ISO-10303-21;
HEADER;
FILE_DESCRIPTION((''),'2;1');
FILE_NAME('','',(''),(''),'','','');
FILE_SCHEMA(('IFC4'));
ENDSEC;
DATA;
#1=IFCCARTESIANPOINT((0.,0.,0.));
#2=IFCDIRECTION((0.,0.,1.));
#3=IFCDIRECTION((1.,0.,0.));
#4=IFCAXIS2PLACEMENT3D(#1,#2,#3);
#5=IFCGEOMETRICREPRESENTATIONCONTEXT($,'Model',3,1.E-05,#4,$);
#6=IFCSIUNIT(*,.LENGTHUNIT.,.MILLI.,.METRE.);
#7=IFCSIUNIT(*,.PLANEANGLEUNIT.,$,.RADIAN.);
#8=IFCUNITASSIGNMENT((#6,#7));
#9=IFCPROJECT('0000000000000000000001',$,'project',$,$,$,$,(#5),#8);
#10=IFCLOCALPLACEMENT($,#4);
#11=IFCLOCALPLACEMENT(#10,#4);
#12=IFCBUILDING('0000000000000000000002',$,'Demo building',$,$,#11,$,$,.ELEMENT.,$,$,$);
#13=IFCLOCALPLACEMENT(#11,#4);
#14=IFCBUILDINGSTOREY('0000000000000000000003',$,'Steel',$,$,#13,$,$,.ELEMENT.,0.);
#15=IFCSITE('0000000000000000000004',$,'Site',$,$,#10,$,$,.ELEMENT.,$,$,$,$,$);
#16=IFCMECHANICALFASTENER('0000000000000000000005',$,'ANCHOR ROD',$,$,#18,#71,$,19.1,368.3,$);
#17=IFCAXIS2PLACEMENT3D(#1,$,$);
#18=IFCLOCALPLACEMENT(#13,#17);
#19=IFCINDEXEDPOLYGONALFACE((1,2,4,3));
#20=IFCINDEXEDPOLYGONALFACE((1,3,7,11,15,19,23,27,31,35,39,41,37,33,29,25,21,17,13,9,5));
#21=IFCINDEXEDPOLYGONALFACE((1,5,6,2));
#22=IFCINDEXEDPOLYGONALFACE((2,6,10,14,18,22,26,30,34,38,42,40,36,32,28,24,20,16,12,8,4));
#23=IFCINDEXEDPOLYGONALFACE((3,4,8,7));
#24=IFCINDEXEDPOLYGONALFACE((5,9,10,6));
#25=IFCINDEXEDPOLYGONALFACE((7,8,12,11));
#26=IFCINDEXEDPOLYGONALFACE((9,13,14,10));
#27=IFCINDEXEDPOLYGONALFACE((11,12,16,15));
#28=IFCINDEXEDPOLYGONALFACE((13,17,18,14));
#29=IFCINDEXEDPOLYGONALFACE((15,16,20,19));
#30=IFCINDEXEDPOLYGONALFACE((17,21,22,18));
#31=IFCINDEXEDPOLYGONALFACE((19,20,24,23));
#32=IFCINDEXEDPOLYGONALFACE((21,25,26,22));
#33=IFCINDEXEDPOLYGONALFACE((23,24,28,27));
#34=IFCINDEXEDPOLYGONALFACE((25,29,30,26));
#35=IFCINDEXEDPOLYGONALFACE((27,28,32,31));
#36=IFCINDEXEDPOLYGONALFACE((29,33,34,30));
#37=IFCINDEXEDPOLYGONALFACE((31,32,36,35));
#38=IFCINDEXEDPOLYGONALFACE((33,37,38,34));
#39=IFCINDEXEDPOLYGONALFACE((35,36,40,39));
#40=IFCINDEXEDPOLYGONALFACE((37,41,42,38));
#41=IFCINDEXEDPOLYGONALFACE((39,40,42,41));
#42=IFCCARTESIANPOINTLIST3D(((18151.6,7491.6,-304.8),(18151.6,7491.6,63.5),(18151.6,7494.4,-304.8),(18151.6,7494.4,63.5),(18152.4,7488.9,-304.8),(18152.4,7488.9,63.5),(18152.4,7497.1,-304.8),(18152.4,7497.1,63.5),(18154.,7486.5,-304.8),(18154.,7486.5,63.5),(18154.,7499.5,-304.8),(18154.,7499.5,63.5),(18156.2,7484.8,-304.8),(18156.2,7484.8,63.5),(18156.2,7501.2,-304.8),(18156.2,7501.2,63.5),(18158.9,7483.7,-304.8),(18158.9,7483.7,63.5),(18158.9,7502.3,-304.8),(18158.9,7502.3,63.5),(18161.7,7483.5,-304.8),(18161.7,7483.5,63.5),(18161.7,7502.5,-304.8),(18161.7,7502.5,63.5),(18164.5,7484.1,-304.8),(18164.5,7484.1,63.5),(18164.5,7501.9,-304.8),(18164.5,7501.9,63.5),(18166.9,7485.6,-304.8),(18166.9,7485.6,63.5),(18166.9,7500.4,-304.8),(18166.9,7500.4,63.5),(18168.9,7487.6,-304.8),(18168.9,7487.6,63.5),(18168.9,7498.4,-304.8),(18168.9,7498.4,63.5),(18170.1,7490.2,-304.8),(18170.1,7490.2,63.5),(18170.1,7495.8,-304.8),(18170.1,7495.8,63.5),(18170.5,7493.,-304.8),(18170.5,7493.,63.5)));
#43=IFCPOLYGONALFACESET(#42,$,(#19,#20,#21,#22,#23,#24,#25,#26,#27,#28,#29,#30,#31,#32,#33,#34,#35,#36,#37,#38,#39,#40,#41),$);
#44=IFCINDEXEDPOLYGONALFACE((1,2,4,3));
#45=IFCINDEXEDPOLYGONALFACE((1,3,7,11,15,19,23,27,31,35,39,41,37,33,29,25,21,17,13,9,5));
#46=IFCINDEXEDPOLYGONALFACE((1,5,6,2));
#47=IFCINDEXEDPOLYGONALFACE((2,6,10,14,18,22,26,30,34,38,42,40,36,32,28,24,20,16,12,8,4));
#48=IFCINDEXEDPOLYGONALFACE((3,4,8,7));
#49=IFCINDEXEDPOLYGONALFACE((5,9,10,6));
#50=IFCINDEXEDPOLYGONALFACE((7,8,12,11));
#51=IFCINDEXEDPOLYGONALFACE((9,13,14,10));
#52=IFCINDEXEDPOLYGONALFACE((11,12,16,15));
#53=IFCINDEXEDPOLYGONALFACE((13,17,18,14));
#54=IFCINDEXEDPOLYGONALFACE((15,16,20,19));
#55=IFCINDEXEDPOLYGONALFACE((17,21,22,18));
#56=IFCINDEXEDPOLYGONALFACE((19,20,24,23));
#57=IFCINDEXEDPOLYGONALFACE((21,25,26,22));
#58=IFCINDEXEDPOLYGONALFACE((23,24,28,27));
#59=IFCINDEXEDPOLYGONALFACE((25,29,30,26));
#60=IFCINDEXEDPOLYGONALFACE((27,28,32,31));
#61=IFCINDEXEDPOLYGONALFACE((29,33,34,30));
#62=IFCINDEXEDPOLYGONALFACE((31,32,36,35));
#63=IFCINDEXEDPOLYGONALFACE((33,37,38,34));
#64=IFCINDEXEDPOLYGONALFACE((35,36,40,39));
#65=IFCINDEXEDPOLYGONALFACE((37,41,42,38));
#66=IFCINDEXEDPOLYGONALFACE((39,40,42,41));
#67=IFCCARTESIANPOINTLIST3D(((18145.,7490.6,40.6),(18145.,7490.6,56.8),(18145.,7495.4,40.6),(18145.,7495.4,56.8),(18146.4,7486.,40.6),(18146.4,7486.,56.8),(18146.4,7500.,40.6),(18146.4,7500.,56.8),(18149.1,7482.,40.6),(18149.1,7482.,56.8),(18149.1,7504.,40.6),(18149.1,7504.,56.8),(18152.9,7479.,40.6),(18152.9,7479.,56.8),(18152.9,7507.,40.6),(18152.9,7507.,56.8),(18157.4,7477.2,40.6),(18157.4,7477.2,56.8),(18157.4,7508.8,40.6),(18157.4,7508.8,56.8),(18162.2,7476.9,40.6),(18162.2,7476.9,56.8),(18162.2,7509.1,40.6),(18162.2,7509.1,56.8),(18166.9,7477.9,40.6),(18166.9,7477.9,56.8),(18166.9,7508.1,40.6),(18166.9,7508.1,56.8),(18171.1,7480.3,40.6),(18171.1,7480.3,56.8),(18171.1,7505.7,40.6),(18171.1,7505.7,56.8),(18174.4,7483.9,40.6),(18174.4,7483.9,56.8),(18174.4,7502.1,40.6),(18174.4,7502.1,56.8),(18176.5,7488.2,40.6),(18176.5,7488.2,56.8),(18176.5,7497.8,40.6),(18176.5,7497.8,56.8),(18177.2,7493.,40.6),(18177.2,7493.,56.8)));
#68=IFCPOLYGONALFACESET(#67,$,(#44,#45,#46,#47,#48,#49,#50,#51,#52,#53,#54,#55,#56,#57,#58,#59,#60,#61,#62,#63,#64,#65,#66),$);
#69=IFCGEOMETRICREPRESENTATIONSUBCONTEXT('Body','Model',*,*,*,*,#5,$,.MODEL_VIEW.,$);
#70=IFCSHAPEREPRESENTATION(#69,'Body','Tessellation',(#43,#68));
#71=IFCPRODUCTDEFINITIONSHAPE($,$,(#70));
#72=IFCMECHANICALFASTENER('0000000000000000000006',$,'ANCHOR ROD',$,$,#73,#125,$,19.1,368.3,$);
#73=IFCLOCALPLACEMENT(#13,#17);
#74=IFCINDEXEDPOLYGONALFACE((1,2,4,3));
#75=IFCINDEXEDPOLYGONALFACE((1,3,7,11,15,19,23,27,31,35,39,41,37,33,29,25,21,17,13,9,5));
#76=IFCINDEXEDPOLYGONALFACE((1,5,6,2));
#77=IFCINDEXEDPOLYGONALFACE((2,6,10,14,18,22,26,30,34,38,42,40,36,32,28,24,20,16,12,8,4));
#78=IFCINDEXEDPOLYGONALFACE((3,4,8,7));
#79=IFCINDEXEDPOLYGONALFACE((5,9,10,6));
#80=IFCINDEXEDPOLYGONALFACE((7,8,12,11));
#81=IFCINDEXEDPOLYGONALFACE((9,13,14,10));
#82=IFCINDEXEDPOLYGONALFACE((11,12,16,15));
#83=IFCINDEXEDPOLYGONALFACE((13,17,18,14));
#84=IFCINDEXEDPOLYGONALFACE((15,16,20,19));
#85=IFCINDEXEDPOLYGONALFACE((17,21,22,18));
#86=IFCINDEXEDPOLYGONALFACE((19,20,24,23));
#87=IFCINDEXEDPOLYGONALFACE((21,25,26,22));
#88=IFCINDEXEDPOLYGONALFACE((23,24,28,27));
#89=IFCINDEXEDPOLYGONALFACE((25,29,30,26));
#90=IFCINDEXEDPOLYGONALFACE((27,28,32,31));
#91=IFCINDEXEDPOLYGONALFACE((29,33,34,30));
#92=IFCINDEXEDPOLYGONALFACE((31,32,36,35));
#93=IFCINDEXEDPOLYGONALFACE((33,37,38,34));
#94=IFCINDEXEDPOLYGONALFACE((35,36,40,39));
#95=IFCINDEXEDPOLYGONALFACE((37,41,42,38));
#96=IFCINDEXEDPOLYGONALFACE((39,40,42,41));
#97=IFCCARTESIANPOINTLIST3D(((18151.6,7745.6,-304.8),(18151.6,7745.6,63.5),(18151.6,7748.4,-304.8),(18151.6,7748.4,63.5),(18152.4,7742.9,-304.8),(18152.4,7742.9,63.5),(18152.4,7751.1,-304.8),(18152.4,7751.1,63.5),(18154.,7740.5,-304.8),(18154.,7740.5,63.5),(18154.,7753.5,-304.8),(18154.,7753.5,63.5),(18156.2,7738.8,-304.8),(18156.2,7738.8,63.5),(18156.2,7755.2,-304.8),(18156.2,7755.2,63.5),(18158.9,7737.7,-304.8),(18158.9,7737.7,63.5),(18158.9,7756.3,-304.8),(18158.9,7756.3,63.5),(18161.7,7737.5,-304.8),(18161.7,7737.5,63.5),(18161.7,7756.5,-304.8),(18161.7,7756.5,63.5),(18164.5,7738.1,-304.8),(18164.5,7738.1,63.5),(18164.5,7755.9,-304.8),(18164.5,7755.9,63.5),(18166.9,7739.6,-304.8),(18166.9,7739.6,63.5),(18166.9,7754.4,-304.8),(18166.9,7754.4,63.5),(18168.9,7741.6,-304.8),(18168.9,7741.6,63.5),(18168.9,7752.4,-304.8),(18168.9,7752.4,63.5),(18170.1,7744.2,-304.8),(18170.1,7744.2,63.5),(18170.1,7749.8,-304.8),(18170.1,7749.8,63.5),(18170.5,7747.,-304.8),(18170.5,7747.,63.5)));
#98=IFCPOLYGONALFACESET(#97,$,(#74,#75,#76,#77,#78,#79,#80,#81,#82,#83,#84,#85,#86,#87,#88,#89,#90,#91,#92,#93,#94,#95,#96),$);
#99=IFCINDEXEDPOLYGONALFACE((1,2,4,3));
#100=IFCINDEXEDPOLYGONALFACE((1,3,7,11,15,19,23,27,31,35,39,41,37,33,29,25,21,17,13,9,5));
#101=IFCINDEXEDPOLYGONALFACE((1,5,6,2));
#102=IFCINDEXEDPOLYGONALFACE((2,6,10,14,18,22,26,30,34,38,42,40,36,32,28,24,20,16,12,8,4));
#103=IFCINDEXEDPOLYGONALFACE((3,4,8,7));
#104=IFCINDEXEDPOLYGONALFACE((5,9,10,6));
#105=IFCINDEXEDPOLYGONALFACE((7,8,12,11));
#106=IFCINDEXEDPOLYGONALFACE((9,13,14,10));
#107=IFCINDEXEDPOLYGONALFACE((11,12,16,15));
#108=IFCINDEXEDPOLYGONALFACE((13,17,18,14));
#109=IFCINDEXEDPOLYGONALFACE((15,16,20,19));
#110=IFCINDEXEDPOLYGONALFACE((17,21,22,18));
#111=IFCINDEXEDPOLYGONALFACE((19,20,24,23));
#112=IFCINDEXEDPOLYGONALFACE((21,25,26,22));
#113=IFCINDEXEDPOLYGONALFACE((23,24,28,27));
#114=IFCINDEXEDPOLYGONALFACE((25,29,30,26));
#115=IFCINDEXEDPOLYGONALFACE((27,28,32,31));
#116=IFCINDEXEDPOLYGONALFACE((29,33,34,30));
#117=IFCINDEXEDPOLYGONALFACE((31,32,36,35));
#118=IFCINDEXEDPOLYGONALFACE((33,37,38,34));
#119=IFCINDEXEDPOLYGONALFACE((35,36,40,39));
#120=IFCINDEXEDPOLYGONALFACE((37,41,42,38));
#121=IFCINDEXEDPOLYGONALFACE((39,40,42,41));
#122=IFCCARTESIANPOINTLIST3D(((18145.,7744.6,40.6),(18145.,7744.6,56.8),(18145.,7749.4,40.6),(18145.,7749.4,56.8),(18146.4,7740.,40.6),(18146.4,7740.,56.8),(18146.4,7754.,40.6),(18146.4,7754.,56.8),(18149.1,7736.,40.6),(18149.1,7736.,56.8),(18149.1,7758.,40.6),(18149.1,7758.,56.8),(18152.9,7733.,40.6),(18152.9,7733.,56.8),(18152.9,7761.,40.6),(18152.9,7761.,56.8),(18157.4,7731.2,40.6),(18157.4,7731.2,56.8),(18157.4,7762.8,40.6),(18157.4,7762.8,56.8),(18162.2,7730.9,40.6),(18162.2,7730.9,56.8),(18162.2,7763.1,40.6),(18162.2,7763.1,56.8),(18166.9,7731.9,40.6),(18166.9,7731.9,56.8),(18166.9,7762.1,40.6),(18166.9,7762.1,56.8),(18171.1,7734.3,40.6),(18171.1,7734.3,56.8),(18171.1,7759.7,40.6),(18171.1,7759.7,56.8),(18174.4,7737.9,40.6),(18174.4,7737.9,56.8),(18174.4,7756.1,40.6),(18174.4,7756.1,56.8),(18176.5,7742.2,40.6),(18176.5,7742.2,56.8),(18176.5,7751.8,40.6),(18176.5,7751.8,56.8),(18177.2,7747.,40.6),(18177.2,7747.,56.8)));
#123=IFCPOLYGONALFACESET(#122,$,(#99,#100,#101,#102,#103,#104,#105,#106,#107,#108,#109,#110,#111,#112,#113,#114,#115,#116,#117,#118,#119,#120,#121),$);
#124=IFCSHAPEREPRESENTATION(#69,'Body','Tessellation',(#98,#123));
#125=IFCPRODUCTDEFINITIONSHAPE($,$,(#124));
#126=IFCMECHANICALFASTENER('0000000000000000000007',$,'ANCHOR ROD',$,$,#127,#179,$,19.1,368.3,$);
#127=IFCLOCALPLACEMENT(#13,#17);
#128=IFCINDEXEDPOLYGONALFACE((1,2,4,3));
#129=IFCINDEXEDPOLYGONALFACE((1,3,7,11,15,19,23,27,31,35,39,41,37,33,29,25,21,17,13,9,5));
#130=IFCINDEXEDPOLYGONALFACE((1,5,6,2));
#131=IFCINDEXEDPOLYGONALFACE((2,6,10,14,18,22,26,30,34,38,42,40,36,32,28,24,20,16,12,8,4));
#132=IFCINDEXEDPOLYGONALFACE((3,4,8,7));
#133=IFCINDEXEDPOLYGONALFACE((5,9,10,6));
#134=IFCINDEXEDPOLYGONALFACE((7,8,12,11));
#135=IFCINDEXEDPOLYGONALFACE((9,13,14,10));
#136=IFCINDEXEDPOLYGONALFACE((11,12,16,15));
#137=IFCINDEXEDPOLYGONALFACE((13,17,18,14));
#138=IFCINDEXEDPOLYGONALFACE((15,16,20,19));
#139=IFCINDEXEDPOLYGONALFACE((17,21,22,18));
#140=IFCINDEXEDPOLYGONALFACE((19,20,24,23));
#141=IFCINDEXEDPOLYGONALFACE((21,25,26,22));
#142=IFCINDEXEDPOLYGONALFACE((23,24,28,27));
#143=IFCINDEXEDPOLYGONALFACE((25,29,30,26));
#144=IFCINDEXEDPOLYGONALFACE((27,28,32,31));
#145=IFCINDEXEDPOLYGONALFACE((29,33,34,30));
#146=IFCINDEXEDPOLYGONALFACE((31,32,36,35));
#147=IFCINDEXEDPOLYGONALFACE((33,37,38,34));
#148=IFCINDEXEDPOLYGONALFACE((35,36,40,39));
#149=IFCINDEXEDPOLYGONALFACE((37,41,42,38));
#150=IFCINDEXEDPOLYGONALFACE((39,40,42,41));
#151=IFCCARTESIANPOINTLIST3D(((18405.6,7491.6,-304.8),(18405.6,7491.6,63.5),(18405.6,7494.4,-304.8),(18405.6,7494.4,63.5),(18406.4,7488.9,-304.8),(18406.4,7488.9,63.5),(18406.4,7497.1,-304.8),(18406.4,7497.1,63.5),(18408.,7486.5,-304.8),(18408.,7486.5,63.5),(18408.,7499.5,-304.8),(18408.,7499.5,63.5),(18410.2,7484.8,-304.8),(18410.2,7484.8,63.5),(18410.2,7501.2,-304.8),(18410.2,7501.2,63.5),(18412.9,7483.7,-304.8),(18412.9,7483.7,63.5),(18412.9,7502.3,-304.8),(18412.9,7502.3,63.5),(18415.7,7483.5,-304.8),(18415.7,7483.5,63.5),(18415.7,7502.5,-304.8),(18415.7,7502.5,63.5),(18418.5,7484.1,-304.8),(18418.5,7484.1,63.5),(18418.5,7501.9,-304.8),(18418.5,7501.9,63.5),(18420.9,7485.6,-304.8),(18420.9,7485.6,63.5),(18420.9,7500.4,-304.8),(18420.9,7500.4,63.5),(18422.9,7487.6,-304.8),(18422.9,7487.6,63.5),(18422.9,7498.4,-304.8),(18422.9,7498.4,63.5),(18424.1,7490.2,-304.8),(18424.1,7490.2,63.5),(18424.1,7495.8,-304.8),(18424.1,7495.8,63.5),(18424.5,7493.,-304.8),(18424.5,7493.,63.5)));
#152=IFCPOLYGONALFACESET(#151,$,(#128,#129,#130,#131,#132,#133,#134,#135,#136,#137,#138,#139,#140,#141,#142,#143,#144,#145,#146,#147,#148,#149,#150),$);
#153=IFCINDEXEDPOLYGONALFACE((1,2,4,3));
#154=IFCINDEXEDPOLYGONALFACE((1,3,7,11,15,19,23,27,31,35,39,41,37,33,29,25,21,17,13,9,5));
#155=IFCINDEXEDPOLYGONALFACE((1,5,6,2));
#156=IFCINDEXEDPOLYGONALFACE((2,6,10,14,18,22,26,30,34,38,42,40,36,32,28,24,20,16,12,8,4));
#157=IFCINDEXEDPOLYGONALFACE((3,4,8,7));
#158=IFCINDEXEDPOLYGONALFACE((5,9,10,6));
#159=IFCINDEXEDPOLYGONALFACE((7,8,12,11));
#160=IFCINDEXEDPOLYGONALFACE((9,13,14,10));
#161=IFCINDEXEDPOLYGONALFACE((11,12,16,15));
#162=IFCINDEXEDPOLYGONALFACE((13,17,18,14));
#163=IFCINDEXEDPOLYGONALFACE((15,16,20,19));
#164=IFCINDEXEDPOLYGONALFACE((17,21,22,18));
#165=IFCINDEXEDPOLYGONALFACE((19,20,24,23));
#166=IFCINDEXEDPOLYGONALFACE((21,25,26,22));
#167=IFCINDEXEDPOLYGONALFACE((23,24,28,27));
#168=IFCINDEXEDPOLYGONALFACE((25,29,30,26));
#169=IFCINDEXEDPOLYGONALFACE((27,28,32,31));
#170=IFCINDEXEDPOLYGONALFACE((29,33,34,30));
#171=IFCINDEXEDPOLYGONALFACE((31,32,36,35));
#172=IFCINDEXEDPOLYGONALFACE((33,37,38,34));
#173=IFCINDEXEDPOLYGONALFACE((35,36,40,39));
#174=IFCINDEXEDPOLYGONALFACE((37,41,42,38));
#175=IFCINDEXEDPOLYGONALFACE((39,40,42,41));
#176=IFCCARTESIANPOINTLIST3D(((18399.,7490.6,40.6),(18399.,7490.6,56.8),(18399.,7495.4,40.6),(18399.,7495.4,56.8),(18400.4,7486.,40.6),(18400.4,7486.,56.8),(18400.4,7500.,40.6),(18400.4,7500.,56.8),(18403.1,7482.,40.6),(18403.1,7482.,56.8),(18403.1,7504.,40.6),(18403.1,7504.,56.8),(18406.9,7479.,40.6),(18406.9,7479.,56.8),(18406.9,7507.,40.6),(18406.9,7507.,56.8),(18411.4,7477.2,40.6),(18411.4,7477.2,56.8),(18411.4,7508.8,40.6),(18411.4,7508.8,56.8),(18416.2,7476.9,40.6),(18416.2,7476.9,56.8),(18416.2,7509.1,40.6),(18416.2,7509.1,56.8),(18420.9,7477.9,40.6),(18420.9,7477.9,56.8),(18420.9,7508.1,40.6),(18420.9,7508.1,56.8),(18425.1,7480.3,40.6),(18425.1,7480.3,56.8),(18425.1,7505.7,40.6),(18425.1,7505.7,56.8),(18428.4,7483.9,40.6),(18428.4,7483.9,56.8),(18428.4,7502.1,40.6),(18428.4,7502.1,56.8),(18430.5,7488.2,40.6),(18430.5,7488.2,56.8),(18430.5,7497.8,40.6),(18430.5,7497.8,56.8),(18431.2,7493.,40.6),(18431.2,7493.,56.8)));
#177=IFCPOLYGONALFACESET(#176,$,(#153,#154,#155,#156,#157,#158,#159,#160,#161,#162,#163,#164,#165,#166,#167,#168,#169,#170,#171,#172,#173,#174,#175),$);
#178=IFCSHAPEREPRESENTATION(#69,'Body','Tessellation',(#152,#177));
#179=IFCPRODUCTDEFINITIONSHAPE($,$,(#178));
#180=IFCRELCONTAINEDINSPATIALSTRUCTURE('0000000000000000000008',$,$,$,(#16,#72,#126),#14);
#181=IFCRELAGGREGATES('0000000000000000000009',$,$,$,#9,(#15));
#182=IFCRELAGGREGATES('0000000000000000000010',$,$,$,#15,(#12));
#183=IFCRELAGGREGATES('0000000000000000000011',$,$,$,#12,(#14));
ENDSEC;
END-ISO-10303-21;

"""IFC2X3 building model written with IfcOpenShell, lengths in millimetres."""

from ifc_helpers import new_model, si_unit, frame, origin, origin_with_axes, origin_2d, place, context, subcontext, project, spatial, circle, extrude, element, save


model = new_model("IFC2X3")

# Units and contexts
model_context = context("Model", 3, precision=1e-05, world=origin_with_axes())
body_context = subcontext(model_context, "Body", "Model", "MODEL_VIEW")
ifc_project = project(units=[si_unit("LENGTHUNIT", "METRE", prefix="MILLI"), si_unit("PLANEANGLEUNIT", "RADIAN")], contexts=[model_context])

# Site, building, storey
site_placement = place(None, origin_with_axes())
site = spatial("IfcSite", under=ifc_project, at=site_placement, Name="Site", CompositionType="ELEMENT")
building_placement = place(site_placement, origin_with_axes())
building = spatial("IfcBuilding", under=site, at=building_placement, Name="Demo building", CompositionType="ELEMENT")
placement = place(building_placement, origin_with_axes())
storey = spatial("IfcBuildingStorey", under=building, at=placement, Name="Steel", CompositionType="ELEMENT", Elevation=0.0)

# Mechanical fasteners
for number, where, z_axis, x_axis, name in (
    (1, (18161.0, 7493.0, -304.8), (0.0, 0.0, 1.0), (1.0, 0.0, 0.0), "ANCHOR ROD"),
    (2, (18161.0, 7747.0, -304.8), (0.0, 0.0, 1.0), (1.0, 0.0, 0.0), "ANCHOR ROD"),
    (3, (18415.0, 7493.0, -304.8), (0.0, 0.0, 1.0), (1.0, 0.0, 0.0), "ANCHOR ROD"),
):
    element("IfcMechanicalFastener", number, at=place(placement, frame(where, z_axis=z_axis, x_axis=x_axis)), inside=storey, Name=name, NominalDiameter=19.1, NominalLength=368.3, context=body_context, shape_type="SweptSolid", body=[
        extrude(circle(Radius=9.5, at=origin_2d()), origin(), (0.0, 0.0, 1.0), 368.3),
        extrude(circle(Radius=16.2, at=origin_2d()), frame((0.0, 0.0, 345.4)), (0.0, 0.0, 1.0), 16.2),
    ])

save(model, "model.ifc")
